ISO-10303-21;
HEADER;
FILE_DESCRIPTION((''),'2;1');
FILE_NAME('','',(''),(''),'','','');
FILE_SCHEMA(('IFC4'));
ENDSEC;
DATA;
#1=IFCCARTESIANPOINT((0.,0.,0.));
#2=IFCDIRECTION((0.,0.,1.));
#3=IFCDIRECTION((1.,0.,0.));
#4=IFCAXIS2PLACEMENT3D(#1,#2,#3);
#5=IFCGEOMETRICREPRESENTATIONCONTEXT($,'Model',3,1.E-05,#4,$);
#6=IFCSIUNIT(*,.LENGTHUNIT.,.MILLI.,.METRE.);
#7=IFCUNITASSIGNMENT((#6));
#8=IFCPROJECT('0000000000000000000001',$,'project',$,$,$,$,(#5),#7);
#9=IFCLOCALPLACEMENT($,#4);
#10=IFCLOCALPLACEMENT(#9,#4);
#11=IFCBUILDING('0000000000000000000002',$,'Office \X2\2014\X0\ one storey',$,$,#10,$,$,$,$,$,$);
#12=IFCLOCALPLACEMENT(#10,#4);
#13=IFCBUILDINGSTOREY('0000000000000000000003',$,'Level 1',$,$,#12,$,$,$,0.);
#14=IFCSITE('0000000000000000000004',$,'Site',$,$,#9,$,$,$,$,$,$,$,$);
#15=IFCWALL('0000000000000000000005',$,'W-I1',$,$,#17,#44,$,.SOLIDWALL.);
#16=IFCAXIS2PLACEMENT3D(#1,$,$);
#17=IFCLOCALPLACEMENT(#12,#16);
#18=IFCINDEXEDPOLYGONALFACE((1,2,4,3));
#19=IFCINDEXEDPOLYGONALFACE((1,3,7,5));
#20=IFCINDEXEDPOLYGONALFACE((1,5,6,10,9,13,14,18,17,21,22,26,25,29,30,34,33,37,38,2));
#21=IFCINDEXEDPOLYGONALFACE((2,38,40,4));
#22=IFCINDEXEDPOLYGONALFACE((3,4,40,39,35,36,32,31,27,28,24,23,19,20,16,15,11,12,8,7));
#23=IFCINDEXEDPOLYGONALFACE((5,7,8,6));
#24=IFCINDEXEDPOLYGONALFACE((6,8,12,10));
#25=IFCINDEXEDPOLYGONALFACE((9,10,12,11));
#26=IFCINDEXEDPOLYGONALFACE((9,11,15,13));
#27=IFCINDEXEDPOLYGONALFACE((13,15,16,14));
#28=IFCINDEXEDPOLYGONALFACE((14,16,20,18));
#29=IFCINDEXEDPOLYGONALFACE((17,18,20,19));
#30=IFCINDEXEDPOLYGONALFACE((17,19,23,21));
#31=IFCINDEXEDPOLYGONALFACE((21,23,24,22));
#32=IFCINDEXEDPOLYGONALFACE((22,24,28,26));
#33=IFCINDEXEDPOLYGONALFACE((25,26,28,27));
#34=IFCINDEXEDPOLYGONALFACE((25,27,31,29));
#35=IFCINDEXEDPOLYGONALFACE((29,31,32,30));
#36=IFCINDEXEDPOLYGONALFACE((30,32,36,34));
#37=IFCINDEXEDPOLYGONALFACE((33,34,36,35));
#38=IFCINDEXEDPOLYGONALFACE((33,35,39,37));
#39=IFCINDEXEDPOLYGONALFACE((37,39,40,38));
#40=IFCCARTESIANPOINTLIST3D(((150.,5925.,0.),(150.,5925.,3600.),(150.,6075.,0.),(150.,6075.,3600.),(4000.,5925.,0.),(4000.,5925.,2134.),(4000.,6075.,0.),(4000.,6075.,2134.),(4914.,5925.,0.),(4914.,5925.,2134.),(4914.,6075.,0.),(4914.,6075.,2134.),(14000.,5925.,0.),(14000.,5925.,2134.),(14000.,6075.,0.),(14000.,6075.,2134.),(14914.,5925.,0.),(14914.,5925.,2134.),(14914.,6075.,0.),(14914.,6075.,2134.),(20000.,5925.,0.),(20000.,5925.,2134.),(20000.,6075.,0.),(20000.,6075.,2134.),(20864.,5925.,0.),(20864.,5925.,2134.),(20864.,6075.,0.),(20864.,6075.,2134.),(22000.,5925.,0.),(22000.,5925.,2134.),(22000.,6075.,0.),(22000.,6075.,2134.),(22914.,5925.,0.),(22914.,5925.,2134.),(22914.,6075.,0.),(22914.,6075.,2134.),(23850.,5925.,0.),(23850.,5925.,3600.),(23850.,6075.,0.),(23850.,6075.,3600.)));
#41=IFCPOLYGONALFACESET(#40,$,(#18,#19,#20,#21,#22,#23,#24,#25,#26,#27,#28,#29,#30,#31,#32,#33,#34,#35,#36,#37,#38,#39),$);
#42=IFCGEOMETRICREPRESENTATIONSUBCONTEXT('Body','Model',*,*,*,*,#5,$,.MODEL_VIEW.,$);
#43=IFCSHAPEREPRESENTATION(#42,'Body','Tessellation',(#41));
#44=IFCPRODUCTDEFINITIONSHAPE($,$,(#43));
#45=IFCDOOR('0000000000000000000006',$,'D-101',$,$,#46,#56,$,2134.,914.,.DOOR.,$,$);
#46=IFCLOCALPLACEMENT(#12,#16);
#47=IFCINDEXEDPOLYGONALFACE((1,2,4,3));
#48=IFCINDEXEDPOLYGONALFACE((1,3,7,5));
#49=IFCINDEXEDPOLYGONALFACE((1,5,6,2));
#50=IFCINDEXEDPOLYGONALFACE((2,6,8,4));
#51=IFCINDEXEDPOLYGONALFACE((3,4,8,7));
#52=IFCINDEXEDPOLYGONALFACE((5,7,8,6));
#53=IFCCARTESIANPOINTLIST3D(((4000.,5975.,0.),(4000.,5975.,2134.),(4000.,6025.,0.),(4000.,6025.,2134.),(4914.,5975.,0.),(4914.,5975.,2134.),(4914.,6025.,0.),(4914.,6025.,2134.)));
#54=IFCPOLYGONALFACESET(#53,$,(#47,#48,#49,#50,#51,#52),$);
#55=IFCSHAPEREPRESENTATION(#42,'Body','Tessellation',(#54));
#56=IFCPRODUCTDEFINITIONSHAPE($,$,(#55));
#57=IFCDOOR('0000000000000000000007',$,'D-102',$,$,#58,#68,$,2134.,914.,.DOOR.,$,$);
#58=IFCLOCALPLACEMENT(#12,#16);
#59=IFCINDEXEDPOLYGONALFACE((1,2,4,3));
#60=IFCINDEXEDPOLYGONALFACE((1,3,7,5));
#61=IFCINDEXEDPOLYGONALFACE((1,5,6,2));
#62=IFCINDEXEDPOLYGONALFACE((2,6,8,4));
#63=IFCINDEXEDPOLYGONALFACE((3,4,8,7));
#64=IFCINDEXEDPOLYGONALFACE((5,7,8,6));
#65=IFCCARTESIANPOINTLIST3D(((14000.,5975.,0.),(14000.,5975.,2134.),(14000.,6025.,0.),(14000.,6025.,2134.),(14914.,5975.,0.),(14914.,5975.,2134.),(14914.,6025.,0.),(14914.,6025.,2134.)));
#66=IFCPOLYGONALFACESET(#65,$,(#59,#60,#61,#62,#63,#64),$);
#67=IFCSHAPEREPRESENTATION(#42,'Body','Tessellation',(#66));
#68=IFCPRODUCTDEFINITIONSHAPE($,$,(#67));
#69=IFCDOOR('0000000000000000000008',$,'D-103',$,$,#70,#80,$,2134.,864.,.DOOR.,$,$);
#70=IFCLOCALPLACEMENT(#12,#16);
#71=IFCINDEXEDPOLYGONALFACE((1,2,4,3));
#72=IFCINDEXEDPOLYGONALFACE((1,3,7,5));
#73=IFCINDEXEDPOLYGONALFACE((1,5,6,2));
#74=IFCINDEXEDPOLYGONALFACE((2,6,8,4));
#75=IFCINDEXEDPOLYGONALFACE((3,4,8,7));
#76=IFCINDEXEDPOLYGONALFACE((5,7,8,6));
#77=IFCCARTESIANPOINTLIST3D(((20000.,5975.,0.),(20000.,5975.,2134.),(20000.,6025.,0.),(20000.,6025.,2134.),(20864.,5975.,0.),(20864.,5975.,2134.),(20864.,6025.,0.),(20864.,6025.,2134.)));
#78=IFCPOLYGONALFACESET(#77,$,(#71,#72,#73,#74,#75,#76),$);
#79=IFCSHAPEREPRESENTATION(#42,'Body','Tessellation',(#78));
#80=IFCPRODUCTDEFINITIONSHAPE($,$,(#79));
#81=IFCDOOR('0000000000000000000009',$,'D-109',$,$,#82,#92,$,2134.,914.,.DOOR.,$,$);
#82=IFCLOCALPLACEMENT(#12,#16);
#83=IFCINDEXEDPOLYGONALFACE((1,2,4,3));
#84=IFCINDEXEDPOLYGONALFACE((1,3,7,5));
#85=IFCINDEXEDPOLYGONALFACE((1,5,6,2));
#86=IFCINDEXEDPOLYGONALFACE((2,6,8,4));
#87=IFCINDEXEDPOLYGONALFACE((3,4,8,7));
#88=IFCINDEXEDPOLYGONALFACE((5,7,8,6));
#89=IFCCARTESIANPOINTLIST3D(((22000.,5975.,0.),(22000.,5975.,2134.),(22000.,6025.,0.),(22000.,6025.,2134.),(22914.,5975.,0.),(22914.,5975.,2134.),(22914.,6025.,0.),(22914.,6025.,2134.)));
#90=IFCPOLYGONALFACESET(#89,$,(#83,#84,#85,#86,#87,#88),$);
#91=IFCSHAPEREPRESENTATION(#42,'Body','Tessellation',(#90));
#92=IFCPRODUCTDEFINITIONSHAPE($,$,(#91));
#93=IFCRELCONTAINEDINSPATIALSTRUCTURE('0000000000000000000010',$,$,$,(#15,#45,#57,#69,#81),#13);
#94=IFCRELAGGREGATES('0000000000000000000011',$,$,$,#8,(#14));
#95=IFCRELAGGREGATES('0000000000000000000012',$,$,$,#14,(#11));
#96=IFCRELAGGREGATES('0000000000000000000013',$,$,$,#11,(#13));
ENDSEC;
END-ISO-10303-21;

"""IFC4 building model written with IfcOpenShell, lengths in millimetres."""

from ifc_helpers import new_model, si_unit, frame, frame_2d, origin, origin_with_axes, place, context, subcontext, project, spatial, rectangle, extrude, element, fill, save


model = new_model("IFC4")

# Units and contexts
model_context = context("Model", 3, precision=1e-05, world=origin_with_axes())
body_context = subcontext(model_context, "Body", "Model", "MODEL_VIEW")
ifc_project = project(units=[si_unit("LENGTHUNIT", "METRE", prefix="MILLI")], contexts=[model_context])

# Site, building, storey
site_placement = place(None, origin_with_axes())
site = spatial("IfcSite", under=ifc_project, at=site_placement, Name="Site")
building_placement = place(site_placement, origin_with_axes())
building = spatial("IfcBuilding", under=site, at=building_placement, Name="Office — one storey")
storey_placement = place(building_placement, origin_with_axes())
storey = spatial("IfcBuildingStorey", under=building, at=storey_placement, Name="Level 1", Elevation=0.0)

# Wall, openings, doors
wall_1_placement = place(storey_placement, frame((0.0, 5925.0, 0.0), z_axis=(0.0, 0.0, 1.0), x_axis=(1.0, 0.0, 0.0)))
wall_1 = element("IfcWall", 1, at=wall_1_placement, inside=storey, Name="W-I1", PredefinedType="SOLIDWALL", context=body_context, shape_type="SweptSolid", body=[
    extrude(rectangle(XDim=23700.0, YDim=150.0, at=frame_2d((12000.0, 75.0))), origin(), (0.0, 0.0, 1.0), 3600.0),
])
opening_1_placement = place(wall_1_placement, frame((4000.0, -10.0, 0.0), z_axis=(0.0, 0.0, 1.0), x_axis=(1.0, 0.0, 0.0)))
opening_1 = element("IfcOpeningElement", 2, at=opening_1_placement, cuts=wall_1, context=body_context, shape_type="SweptSolid", body=[
    extrude(rectangle(XDim=914.0, YDim=170.0, at=frame_2d((457.0, 85.0))), origin(), (0.0, 0.0, 1.0), 2134.0),
])
opening_2_placement = place(wall_1_placement, frame((14000.0, -10.0, 0.0), z_axis=(0.0, 0.0, 1.0), x_axis=(1.0, 0.0, 0.0)))
opening_2 = element("IfcOpeningElement", 3, at=opening_2_placement, cuts=wall_1, context=body_context, shape_type="SweptSolid", body=[
    extrude(rectangle(XDim=914.0, YDim=170.0, at=frame_2d((457.0, 85.0))), origin(), (0.0, 0.0, 1.0), 2134.0),
])
opening_3_placement = place(wall_1_placement, frame((20000.0, -10.0, 0.0), z_axis=(0.0, 0.0, 1.0), x_axis=(1.0, 0.0, 0.0)))
opening_3 = element("IfcOpeningElement", 4, at=opening_3_placement, cuts=wall_1, context=body_context, shape_type="SweptSolid", body=[
    extrude(rectangle(XDim=864.0, YDim=170.0, at=frame_2d((432.0, 85.0))), origin(), (0.0, 0.0, 1.0), 2134.0),
])
opening_4_placement = place(wall_1_placement, frame((22000.0, -10.0, 0.0), z_axis=(0.0, 0.0, 1.0), x_axis=(1.0, 0.0, 0.0)))
opening_4 = element("IfcOpeningElement", 5, at=opening_4_placement, cuts=wall_1, context=body_context, shape_type="SweptSolid", body=[
    extrude(rectangle(XDim=914.0, YDim=170.0, at=frame_2d((457.0, 85.0))), origin(), (0.0, 0.0, 1.0), 2134.0),
])
door_1_placement = place(storey_placement, frame((4000.0, 5975.0, 0.0), z_axis=(0.0, 0.0, 1.0), x_axis=(1.0, 0.0, 0.0)))
door_1 = element("IfcDoor", 6, at=door_1_placement, inside=storey, Name="D-101", OverallHeight=2134.0, OverallWidth=914.0, PredefinedType="DOOR", context=body_context, shape_type="SweptSolid", body=[
    extrude(rectangle(XDim=914.0, YDim=50.0, at=frame_2d((457.0, 25.0))), origin(), (0.0, 0.0, 1.0), 2134.0),
])
fill(opening_1, door_1)
door_2_placement = place(storey_placement, frame((14000.0, 5975.0, 0.0), z_axis=(0.0, 0.0, 1.0), x_axis=(1.0, 0.0, 0.0)))
door_2 = element("IfcDoor", 7, at=door_2_placement, inside=storey, Name="D-102", OverallHeight=2134.0, OverallWidth=914.0, PredefinedType="DOOR", context=body_context, shape_type="SweptSolid", body=[
    extrude(rectangle(XDim=914.0, YDim=50.0, at=frame_2d((457.0, 25.0))), origin(), (0.0, 0.0, 1.0), 2134.0),
])
fill(opening_2, door_2)
door_3_placement = place(storey_placement, frame((20000.0, 5975.0, 0.0), z_axis=(0.0, 0.0, 1.0), x_axis=(1.0, 0.0, 0.0)))
door_3 = element("IfcDoor", 8, at=door_3_placement, inside=storey, Name="D-103", OverallHeight=2134.0, OverallWidth=864.0, PredefinedType="DOOR", context=body_context, shape_type="SweptSolid", body=[
    extrude(rectangle(XDim=864.0, YDim=50.0, at=frame_2d((432.0, 25.0))), origin(), (0.0, 0.0, 1.0), 2134.0),
])
fill(opening_3, door_3)
door_4_placement = place(storey_placement, frame((22000.0, 5975.0, 0.0), z_axis=(0.0, 0.0, 1.0), x_axis=(1.0, 0.0, 0.0)))
door_4 = element("IfcDoor", 9, at=door_4_placement, inside=storey, Name="D-109", OverallHeight=2134.0, OverallWidth=914.0, PredefinedType="DOOR", context=body_context, shape_type="SweptSolid", body=[
    extrude(rectangle(XDim=914.0, YDim=50.0, at=frame_2d((457.0, 25.0))), origin(), (0.0, 0.0, 1.0), 2134.0),
])
fill(opening_4, door_4)

save(model, "model.ifc")
